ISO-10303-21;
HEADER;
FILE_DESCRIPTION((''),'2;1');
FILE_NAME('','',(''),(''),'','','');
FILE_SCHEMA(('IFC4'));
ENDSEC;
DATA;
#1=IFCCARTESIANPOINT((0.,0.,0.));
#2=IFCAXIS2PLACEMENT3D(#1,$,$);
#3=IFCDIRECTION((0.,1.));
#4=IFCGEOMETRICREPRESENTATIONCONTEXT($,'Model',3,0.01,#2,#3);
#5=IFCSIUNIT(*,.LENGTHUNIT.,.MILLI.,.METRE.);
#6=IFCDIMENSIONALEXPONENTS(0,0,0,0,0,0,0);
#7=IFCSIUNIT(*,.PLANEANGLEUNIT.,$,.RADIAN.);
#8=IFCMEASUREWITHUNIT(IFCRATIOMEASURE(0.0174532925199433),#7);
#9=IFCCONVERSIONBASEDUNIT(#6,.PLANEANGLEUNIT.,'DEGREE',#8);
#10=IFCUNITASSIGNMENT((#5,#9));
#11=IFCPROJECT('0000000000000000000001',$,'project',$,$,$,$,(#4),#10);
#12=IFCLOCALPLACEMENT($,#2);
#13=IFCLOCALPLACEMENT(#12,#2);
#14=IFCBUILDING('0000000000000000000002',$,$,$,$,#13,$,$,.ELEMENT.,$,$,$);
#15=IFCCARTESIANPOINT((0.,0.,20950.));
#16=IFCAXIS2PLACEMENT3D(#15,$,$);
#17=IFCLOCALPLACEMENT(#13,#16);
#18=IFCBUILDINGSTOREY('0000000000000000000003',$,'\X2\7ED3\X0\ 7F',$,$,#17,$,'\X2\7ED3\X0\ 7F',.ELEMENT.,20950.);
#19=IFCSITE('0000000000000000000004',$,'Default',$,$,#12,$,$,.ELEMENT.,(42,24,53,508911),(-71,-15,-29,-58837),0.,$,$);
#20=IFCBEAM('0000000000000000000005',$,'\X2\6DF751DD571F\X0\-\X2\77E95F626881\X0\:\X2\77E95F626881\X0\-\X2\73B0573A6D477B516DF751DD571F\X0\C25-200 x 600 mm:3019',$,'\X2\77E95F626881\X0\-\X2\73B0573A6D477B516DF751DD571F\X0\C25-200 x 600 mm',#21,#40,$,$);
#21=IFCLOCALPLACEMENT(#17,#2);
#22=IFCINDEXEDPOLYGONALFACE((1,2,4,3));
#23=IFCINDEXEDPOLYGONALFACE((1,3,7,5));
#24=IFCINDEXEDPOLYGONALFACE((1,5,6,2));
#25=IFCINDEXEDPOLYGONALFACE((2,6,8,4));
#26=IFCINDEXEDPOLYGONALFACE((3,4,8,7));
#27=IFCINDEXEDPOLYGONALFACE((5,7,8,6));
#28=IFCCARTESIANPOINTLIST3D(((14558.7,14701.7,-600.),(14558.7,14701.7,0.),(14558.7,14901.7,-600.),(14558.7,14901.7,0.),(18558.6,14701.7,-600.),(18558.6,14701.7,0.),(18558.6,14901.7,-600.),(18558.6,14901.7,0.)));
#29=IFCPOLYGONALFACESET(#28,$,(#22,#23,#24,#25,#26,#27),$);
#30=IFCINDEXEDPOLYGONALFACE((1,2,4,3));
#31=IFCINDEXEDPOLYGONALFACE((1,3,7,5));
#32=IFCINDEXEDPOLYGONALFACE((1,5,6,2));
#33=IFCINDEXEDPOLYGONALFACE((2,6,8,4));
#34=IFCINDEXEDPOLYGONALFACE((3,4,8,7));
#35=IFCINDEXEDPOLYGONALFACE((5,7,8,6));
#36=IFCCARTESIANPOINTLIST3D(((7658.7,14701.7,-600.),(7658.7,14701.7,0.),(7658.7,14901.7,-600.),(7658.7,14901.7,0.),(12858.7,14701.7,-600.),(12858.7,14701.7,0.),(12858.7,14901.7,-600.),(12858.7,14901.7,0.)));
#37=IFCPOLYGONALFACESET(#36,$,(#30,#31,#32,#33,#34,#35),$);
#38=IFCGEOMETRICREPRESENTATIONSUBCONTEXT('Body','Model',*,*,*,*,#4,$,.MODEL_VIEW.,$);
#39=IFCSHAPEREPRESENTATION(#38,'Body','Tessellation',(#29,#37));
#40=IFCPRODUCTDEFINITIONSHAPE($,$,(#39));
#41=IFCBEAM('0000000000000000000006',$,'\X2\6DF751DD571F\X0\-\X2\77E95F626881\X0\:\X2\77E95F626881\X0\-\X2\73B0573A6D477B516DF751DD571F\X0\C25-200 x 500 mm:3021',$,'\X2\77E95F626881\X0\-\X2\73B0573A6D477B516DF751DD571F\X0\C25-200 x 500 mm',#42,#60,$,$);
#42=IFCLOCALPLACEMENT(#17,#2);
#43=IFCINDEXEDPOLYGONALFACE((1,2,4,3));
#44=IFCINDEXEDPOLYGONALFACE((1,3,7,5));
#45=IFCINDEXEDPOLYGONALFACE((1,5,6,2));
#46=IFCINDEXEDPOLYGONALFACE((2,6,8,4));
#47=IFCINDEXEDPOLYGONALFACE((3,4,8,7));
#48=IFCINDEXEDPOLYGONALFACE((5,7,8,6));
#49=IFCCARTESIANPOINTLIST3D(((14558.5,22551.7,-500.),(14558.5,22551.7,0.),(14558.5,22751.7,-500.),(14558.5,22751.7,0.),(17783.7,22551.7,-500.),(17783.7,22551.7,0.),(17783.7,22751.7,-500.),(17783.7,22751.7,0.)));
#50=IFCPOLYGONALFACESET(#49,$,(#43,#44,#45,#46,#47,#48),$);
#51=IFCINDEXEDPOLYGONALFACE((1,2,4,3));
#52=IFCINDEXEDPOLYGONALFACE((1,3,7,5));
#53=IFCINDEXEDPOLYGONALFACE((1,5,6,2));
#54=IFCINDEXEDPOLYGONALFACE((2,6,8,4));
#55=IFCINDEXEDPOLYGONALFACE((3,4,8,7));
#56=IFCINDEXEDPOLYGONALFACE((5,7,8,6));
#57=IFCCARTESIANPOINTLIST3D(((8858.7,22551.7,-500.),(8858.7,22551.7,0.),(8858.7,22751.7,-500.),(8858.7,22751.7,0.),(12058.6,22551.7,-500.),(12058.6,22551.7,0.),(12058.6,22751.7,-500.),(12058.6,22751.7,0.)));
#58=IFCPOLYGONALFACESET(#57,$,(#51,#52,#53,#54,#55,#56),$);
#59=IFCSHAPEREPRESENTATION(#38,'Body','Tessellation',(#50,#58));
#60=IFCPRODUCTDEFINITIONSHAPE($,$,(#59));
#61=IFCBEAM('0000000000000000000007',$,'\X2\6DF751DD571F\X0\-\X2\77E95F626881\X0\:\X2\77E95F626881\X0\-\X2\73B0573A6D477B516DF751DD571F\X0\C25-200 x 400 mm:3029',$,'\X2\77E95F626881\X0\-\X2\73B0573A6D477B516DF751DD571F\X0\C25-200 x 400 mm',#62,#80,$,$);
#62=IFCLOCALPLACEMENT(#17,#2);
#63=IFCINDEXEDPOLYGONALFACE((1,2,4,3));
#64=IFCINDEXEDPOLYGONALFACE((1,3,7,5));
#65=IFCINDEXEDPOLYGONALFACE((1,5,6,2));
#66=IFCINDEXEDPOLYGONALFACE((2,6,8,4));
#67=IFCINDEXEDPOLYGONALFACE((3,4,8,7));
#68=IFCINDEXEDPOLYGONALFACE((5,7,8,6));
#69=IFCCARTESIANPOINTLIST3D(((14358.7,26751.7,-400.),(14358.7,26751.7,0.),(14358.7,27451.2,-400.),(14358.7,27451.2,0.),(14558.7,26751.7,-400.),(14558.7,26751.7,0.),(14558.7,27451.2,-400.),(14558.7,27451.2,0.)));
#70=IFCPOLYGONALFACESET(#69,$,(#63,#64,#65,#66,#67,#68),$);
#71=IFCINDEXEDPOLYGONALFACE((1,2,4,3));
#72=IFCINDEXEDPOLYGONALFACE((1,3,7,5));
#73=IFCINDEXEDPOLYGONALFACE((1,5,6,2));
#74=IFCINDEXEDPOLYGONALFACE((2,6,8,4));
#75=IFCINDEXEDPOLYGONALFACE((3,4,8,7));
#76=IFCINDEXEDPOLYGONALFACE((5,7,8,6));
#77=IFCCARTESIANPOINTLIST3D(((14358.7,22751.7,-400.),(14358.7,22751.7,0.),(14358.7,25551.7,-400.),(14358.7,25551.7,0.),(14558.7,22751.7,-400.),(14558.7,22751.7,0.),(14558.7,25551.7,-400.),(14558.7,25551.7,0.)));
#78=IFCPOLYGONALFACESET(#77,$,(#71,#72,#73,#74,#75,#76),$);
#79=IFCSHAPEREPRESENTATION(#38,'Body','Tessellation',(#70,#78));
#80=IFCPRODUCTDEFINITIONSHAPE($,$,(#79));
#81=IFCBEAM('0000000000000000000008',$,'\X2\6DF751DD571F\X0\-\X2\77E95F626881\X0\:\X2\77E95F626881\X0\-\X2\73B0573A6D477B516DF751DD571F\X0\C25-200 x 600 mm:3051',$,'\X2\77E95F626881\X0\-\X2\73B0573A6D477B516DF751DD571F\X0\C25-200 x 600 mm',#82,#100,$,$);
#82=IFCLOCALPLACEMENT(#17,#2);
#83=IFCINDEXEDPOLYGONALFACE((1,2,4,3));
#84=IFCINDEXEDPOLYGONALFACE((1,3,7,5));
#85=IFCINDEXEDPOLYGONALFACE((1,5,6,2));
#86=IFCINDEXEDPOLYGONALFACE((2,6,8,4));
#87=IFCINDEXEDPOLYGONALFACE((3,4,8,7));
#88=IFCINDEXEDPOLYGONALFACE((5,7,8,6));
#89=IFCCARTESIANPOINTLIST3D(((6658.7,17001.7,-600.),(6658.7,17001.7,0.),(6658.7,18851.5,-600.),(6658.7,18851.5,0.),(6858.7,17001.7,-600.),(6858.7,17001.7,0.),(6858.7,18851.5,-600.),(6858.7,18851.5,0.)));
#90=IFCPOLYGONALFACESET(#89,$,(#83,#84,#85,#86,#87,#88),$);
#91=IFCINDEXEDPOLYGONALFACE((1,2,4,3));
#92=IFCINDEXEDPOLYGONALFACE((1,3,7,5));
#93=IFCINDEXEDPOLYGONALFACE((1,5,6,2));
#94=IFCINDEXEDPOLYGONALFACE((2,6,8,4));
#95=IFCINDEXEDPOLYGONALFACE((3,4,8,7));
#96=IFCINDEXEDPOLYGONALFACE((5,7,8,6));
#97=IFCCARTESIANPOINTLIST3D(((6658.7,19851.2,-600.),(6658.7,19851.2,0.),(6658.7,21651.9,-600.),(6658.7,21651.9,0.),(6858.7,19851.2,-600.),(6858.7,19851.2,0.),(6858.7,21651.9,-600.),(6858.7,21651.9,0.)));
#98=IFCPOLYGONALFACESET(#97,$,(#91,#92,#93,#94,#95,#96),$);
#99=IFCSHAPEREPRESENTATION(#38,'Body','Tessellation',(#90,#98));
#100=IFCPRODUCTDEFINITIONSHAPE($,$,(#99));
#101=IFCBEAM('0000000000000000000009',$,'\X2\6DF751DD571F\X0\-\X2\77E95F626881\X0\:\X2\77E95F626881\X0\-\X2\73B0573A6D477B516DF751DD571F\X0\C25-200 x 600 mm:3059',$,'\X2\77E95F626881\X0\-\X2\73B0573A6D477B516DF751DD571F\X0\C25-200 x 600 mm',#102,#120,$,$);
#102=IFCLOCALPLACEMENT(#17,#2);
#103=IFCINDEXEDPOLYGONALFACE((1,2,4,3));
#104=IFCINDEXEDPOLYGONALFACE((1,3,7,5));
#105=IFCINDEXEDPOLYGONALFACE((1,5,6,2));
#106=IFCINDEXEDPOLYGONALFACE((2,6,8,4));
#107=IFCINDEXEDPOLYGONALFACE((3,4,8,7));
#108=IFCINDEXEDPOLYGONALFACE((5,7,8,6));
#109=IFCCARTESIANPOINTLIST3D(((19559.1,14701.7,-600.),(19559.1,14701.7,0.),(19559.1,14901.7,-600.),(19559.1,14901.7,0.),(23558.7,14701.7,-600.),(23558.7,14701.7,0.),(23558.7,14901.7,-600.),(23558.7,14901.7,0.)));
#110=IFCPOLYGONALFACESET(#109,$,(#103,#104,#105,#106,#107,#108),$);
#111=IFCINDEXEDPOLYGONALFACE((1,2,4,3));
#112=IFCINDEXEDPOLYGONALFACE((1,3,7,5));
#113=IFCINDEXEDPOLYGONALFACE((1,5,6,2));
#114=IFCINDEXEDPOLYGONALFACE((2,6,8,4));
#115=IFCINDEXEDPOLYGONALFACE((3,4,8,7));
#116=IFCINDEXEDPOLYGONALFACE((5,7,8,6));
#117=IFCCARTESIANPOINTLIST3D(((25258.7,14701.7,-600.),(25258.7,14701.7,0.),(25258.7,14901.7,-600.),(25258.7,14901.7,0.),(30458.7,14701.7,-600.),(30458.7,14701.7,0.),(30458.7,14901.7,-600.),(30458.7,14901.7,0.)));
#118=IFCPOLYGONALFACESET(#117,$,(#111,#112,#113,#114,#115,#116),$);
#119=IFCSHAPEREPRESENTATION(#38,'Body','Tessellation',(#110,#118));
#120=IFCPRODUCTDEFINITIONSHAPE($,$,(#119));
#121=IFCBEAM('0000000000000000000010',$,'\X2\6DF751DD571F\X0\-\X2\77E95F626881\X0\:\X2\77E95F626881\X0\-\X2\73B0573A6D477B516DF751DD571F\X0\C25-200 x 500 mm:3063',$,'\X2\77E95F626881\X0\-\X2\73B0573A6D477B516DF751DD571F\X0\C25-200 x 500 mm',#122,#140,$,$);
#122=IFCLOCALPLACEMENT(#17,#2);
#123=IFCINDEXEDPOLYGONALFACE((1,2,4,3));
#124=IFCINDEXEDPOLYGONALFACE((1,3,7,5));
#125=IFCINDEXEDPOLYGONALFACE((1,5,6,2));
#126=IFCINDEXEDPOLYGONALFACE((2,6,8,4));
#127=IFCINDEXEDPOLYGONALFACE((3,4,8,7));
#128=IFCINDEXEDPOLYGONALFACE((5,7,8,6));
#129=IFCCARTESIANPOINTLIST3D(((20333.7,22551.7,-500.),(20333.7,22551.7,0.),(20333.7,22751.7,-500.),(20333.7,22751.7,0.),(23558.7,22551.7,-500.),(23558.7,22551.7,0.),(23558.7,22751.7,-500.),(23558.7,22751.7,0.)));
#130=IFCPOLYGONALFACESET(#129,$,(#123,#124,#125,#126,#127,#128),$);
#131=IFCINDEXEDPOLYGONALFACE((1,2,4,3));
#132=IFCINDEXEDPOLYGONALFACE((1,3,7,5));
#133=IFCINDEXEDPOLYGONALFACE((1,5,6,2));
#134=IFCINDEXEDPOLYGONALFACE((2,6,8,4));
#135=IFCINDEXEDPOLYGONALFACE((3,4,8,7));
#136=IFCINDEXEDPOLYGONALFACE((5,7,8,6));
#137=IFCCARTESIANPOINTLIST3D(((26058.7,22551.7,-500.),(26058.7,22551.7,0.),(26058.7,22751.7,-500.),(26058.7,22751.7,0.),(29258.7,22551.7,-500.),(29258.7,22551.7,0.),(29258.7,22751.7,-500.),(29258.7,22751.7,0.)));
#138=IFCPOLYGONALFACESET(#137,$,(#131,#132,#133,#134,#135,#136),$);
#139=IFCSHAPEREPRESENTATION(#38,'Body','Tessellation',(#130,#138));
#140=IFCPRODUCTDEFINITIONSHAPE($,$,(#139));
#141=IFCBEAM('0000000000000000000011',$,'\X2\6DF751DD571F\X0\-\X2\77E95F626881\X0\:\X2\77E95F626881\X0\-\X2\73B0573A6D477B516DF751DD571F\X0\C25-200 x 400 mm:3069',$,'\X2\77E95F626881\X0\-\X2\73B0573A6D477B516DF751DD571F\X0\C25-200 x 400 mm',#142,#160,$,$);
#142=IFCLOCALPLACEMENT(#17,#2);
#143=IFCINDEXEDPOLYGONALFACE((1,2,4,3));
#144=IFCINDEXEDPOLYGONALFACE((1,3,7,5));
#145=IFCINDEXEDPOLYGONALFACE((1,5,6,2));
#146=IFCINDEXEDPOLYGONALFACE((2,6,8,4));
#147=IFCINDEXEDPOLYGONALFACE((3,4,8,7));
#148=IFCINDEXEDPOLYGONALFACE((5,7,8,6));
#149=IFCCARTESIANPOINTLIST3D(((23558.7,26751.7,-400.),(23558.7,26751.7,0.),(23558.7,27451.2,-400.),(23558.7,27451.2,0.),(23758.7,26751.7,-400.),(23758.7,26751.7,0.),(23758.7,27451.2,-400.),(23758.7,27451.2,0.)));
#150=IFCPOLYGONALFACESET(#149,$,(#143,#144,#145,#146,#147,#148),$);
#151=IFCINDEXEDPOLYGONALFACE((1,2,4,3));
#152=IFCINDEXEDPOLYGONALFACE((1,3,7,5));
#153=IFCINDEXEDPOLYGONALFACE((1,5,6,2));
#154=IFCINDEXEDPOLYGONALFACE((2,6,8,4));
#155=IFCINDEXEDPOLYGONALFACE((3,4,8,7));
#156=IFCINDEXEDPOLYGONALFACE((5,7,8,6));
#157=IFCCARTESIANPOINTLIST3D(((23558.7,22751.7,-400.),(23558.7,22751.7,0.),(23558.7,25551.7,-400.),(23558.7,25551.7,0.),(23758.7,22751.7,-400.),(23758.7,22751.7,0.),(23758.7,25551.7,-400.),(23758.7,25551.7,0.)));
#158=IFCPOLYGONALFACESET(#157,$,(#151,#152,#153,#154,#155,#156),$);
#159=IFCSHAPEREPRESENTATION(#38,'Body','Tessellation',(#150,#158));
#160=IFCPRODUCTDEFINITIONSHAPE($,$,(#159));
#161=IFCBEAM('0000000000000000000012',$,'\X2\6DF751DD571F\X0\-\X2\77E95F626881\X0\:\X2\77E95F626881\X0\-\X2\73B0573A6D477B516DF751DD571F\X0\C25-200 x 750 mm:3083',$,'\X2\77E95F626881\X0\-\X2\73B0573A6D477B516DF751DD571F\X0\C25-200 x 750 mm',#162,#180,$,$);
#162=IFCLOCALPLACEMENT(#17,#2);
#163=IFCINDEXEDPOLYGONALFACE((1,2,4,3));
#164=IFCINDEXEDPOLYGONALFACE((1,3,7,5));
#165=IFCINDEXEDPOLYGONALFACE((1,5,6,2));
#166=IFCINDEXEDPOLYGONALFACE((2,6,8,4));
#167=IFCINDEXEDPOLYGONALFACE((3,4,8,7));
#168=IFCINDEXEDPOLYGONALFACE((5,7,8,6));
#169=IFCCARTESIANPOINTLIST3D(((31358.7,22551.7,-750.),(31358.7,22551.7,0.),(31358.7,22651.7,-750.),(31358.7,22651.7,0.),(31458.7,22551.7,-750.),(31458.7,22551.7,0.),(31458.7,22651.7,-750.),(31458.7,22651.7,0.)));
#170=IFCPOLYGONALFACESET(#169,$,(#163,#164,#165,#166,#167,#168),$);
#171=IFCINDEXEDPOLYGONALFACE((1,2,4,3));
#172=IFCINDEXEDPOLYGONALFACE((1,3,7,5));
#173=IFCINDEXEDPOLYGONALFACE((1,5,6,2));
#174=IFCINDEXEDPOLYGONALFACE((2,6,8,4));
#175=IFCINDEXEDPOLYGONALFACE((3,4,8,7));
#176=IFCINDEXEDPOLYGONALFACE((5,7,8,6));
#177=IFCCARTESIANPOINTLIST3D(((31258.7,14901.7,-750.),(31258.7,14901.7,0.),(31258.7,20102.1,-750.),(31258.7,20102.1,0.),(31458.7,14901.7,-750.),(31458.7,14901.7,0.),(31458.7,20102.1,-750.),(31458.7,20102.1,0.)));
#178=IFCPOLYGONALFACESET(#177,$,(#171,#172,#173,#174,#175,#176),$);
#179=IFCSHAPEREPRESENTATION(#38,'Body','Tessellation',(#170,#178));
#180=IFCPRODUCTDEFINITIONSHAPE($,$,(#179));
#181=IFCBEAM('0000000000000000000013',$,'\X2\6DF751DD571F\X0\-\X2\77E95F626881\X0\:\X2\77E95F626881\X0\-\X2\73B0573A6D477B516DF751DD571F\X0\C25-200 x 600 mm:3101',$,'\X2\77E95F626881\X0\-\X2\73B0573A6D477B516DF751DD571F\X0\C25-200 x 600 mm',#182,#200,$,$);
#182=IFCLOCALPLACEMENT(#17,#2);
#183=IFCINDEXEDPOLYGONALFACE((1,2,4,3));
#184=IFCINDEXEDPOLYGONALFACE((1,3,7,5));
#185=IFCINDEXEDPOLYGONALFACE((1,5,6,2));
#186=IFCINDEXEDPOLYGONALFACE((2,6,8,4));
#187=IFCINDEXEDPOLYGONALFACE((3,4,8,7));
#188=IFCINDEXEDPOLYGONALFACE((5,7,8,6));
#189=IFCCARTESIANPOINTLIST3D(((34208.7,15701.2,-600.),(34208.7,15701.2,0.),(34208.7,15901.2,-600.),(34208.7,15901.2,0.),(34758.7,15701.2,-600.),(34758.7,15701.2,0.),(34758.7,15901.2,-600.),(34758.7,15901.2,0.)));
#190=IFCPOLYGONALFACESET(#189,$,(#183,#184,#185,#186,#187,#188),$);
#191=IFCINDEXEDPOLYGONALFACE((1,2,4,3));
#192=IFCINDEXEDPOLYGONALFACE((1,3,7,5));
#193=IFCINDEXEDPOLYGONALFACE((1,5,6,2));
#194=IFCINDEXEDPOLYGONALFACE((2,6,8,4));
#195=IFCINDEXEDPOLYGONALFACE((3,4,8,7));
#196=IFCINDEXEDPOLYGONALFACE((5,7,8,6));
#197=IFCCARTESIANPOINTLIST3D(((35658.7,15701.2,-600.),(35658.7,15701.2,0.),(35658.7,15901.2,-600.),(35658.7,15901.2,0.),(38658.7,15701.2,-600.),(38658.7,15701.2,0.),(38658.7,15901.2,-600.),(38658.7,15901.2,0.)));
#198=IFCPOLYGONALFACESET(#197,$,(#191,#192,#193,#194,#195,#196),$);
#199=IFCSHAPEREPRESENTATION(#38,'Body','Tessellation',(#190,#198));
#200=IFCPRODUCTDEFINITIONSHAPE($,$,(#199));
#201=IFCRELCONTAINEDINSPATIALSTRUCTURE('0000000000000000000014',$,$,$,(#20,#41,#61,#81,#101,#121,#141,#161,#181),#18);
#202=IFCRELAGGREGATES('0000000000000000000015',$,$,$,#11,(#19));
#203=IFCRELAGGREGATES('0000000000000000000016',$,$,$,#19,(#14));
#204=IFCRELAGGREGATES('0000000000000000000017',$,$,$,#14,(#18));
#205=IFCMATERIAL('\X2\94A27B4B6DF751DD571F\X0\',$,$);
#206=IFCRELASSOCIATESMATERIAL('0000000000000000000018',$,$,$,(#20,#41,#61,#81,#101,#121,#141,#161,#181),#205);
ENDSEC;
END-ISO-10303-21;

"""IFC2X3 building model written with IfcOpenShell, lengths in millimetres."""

from ifc_helpers import new_model, entity, si_unit, converted_unit, direction, frame, frame_2d, origin, origin_2d_with_axis, place, context, subcontext, project, spatial, rectangle, extrude, source, transform, mapped, material, element, save


model = new_model("IFC2X3")

# Units and contexts
model_context = context("Model", 3, precision=0.01, world=origin(), true_north=direction((0.0, 1.0)))
body_context = subcontext(model_context, "Body", "Model", "MODEL_VIEW")
ifc_project = project(units=[si_unit("LENGTHUNIT", "METRE", prefix="MILLI"), converted_unit("PLANEANGLEUNIT", "DEGREE", entity("IfcRatioMeasure", 0.0174532925199433), si_unit("PLANEANGLEUNIT", "RADIAN"), dimensions=[0, 0, 0, 0, 0, 0, 0])], contexts=[model_context])

# Site, building, storey
site_placement = place(None, origin())
site = spatial("IfcSite", under=ifc_project, at=site_placement, Name="Default", CompositionType="ELEMENT", RefLatitude=(42, 24, 53, 508911), RefLongitude=(-71, -15, -29, -58837), RefElevation=0.0)
building_placement = place(site_placement, origin())
building = spatial("IfcBuilding", under=site, at=building_placement, CompositionType="ELEMENT")
storey_placement = place(building_placement, frame((0.0, 0.0, 20950.0)))
storey = spatial("IfcBuildingStorey", under=building, at=storey_placement, Name="结 7F", LongName="结 7F", CompositionType="ELEMENT", Elevation=20950.0)

# Beams
ifc_material = material(Name="钢筋混凝土")
shared_shape_1 = source(origin(), body_context, "Body", "SweptSolid", [
    extrude(rectangle(XDim=3999.9, YDim=200.0, at=frame_2d((0.0, 0.0), x_axis=(1.0, 0.0))), frame((16558.7, 14801.7, 20350.0), z_axis=(0.0, 0.0, 1.0), x_axis=(-1.0, 0.0, 0.0)), (0.0, 0.0, 1.0), 600.0),
    extrude(rectangle(XDim=5200.0, YDim=200.0, at=frame_2d((0.0, 0.0), x_axis=(1.0, 0.0))), frame((10258.7, 14801.7, 20350.0), z_axis=(0.0, 0.0, 1.0), x_axis=(-1.0, 0.0, 0.0)), (0.0, 0.0, 1.0), 600.0),
])
beam_1_placement = place(storey_placement, frame((0.0, 0.0, -20950.0)))
element("IfcBeam", 1, at=beam_1_placement, inside=storey, material=ifc_material, Name="混凝土-矩形梁:矩形梁-现场浇筑混凝土C25-200 x 600 mm:3019", ObjectType="矩形梁-现场浇筑混凝土C25-200 x 600 mm", context=body_context, shape_type="MappedRepresentation", body=[
    mapped(shared_shape_1, transform((0.0, 0.0, 0.0), scale=1.0)),
])
shared_shape_2 = source(origin(), body_context, "Body", "SweptSolid", [
    extrude(rectangle(XDim=3225.1, YDim=200.0, at=frame_2d((0.0, 0.0), x_axis=(1.0, 0.0))), frame((16171.1, 22651.7, 20450.0), z_axis=(0.0, 0.0, 1.0), x_axis=(-1.0, 0.0, 0.0)), (0.0, 0.0, 1.0), 500.0),
    extrude(rectangle(XDim=3200.0, YDim=200.0, at=frame_2d((0.0, 0.0), x_axis=(1.0, 0.0))), frame((10458.7, 22651.7, 20450.0), z_axis=(0.0, 0.0, 1.0), x_axis=(-1.0, 0.0, 0.0)), (0.0, 0.0, 1.0), 500.0),
])
beam_2_placement = place(storey_placement, frame((0.0, 0.0, -20950.0)))
element("IfcBeam", 2, at=beam_2_placement, inside=storey, material=ifc_material, Name="混凝土-矩形梁:矩形梁-现场浇筑混凝土C25-200 x 500 mm:3021", ObjectType="矩形梁-现场浇筑混凝土C25-200 x 500 mm", context=body_context, shape_type="MappedRepresentation", body=[
    mapped(shared_shape_2, transform((0.0, 0.0, 0.0), scale=1.0)),
])
shared_shape_3 = source(origin(), body_context, "Body", "SweptSolid", [
    extrude(rectangle(XDim=699.5, YDim=200.0, at=origin_2d_with_axis()), frame((14458.7, 27101.5, 20550.0), z_axis=(0.0, 0.0, 1.0), x_axis=(0.0, 1.0, 0.0)), (0.0, 0.0, 1.0), 400.0),
    extrude(rectangle(XDim=2800.0, YDim=200.0, at=frame_2d((0.0, 0.0), x_axis=(1.0, 0.0))), frame((14458.7, 24151.7, 20550.0), z_axis=(0.0, 0.0, 1.0), x_axis=(0.0, 1.0, 0.0)), (0.0, 0.0, 1.0), 400.0),
])
beam_3_placement = place(storey_placement, frame((0.0, 0.0, -20950.0)))
element("IfcBeam", 3, at=beam_3_placement, inside=storey, material=ifc_material, Name="混凝土-矩形梁:矩形梁-现场浇筑混凝土C25-200 x 400 mm:3029", ObjectType="矩形梁-现场浇筑混凝土C25-200 x 400 mm", context=body_context, shape_type="MappedRepresentation", body=[
    mapped(shared_shape_3, transform((0.0, 0.0, 0.0), scale=1.0)),
])
shared_shape_4 = source(origin(), body_context, "Body", "SweptSolid", [
    extrude(rectangle(XDim=1849.8, YDim=200.0, at=frame_2d((0.0, 0.0), x_axis=(1.0, 0.0))), frame((6758.7, 17926.6, 20350.0), z_axis=(0.0, 0.0, 1.0), x_axis=(0.0, 1.0, 0.0)), (0.0, 0.0, 1.0), 600.0),
    extrude(rectangle(XDim=1800.7, YDim=200.0, at=frame_2d((0.0, 0.0), x_axis=(1.0, 0.0))), frame((6758.7, 20751.6, 20350.0), z_axis=(0.0, 0.0, 1.0), x_axis=(0.0, 1.0, 0.0)), (0.0, 0.0, 1.0), 600.0),
])
beam_4_placement = place(storey_placement, frame((0.0, 0.0, -20950.0)))
element("IfcBeam", 4, at=beam_4_placement, inside=storey, material=ifc_material, Name="混凝土-矩形梁:矩形梁-现场浇筑混凝土C25-200 x 600 mm:3051", ObjectType="矩形梁-现场浇筑混凝土C25-200 x 600 mm", context=body_context, shape_type="MappedRepresentation", body=[
    mapped(shared_shape_4, transform((0.0, 0.0, 0.0), scale=1.0)),
])
shared_shape_5 = source(origin(), body_context, "Body", "SweptSolid", [
    extrude(rectangle(XDim=3999.6, YDim=200.0, at=origin_2d_with_axis()), frame((21558.9, 14801.7, 20350.0)), (0.0, 0.0, 1.0), 600.0),
    extrude(rectangle(XDim=5200.0, YDim=200.0, at=frame_2d((0.0, 0.0), x_axis=(1.0, 0.0))), frame((27858.7, 14801.7, 20350.0)), (0.0, 0.0, 1.0), 600.0),
])
beam_5_placement = place(storey_placement, frame((0.0, 0.0, -20950.0)))
element("IfcBeam", 5, at=beam_5_placement, inside=storey, material=ifc_material, Name="混凝土-矩形梁:矩形梁-现场浇筑混凝土C25-200 x 600 mm:3059", ObjectType="矩形梁-现场浇筑混凝土C25-200 x 600 mm", context=body_context, shape_type="MappedRepresentation", body=[
    mapped(shared_shape_5, transform((0.0, 0.0, 0.0), scale=1.0)),
])
shared_shape_6 = source(origin(), body_context, "Body", "SweptSolid", [
    extrude(rectangle(XDim=3225.0, YDim=200.0, at=origin_2d_with_axis()), frame((21946.2, 22651.7, 20450.0)), (0.0, 0.0, 1.0), 500.0),
    extrude(rectangle(XDim=3200.0, YDim=200.0, at=frame_2d((0.0, 0.0), x_axis=(1.0, 0.0))), frame((27658.7, 22651.7, 20450.0)), (0.0, 0.0, 1.0), 500.0),
])
beam_6_placement = place(storey_placement, frame((0.0, 0.0, -20950.0)))
element("IfcBeam", 6, at=beam_6_placement, inside=storey, material=ifc_material, Name="混凝土-矩形梁:矩形梁-现场浇筑混凝土C25-200 x 500 mm:3063", ObjectType="矩形梁-现场浇筑混凝土C25-200 x 500 mm", context=body_context, shape_type="MappedRepresentation", body=[
    mapped(shared_shape_6, transform((0.0, 0.0, 0.0), scale=1.0)),
])
shared_shape_7 = source(origin(), body_context, "Body", "SweptSolid", [
    extrude(rectangle(XDim=699.5, YDim=200.0, at=origin_2d_with_axis()), frame((23658.7, 27101.5, 20550.0), z_axis=(0.0, 0.0, 1.0), x_axis=(0.0, 1.0, 0.0)), (0.0, 0.0, 1.0), 400.0),
    extrude(rectangle(XDim=200.0, YDim=2800.0, at=frame_2d((0.0, 0.0), x_axis=(1.0, 0.0))), frame((23658.7, 24151.7, 20550.0)), (0.0, 0.0, 1.0), 400.0),
])
beam_7_placement = place(storey_placement, frame((0.0, 0.0, -20950.0)))
element("IfcBeam", 7, at=beam_7_placement, inside=storey, material=ifc_material, Name="混凝土-矩形梁:矩形梁-现场浇筑混凝土C25-200 x 400 mm:3069", ObjectType="矩形梁-现场浇筑混凝土C25-200 x 400 mm", context=body_context, shape_type="MappedRepresentation", body=[
    mapped(shared_shape_7, transform((0.0, 0.0, 0.0), scale=1.0)),
])
shared_shape_8 = source(origin(), body_context, "Body", "SweptSolid", [
    extrude(rectangle(XDim=100.0, YDim=100.0, at=frame_2d((0.0, 0.0), x_axis=(1.0, 0.0))), frame((31408.7, 22601.7, 20200.0), z_axis=(0.0, 0.0, 1.0), x_axis=(-1.0, 0.0, 0.0)), (0.0, 0.0, 1.0), 750.0),
    extrude(rectangle(XDim=5200.4, YDim=200.0, at=frame_2d((0.0, 0.0), x_axis=(1.0, 0.0))), frame((31358.7, 17501.9, 20200.0), z_axis=(0.0, 0.0, 1.0), x_axis=(0.0, 1.0, 0.0)), (0.0, 0.0, 1.0), 750.0),
])
beam_8_placement = place(storey_placement, frame((0.0, 0.0, -20950.0)))
element("IfcBeam", 8, at=beam_8_placement, inside=storey, material=ifc_material, Name="混凝土-矩形梁:矩形梁-现场浇筑混凝土C25-200 x 750 mm:3083", ObjectType="矩形梁-现场浇筑混凝土C25-200 x 750 mm", context=body_context, shape_type="MappedRepresentation", body=[
    mapped(shared_shape_8, transform((0.0, 0.0, 0.0), scale=1.0)),
])
shared_shape_9 = source(origin(), body_context, "Body", "SweptSolid", [
    extrude(rectangle(XDim=550.0, YDim=200.0, at=frame_2d((0.0, 0.0), x_axis=(1.0, 0.0))), frame((34483.7, 15801.2, 20350.0)), (0.0, 0.0, 1.0), 600.0),
    extrude(rectangle(XDim=3000.0, YDim=200.0, at=frame_2d((0.0, 0.0), x_axis=(1.0, 0.0))), frame((37158.7, 15801.2, 20350.0), z_axis=(0.0, 0.0, 1.0), x_axis=(-1.0, 0.0, 0.0)), (0.0, 0.0, 1.0), 600.0),
])
beam_9_placement = place(storey_placement, frame((0.0, 0.0, -20950.0)))
element("IfcBeam", 9, at=beam_9_placement, inside=storey, material=ifc_material, Name="混凝土-矩形梁:矩形梁-现场浇筑混凝土C25-200 x 600 mm:3101", ObjectType="矩形梁-现场浇筑混凝土C25-200 x 600 mm", context=body_context, shape_type="MappedRepresentation", body=[
    mapped(shared_shape_9, transform((0.0, 0.0, 0.0), scale=1.0)),
])

save(model, "model.ifc")
